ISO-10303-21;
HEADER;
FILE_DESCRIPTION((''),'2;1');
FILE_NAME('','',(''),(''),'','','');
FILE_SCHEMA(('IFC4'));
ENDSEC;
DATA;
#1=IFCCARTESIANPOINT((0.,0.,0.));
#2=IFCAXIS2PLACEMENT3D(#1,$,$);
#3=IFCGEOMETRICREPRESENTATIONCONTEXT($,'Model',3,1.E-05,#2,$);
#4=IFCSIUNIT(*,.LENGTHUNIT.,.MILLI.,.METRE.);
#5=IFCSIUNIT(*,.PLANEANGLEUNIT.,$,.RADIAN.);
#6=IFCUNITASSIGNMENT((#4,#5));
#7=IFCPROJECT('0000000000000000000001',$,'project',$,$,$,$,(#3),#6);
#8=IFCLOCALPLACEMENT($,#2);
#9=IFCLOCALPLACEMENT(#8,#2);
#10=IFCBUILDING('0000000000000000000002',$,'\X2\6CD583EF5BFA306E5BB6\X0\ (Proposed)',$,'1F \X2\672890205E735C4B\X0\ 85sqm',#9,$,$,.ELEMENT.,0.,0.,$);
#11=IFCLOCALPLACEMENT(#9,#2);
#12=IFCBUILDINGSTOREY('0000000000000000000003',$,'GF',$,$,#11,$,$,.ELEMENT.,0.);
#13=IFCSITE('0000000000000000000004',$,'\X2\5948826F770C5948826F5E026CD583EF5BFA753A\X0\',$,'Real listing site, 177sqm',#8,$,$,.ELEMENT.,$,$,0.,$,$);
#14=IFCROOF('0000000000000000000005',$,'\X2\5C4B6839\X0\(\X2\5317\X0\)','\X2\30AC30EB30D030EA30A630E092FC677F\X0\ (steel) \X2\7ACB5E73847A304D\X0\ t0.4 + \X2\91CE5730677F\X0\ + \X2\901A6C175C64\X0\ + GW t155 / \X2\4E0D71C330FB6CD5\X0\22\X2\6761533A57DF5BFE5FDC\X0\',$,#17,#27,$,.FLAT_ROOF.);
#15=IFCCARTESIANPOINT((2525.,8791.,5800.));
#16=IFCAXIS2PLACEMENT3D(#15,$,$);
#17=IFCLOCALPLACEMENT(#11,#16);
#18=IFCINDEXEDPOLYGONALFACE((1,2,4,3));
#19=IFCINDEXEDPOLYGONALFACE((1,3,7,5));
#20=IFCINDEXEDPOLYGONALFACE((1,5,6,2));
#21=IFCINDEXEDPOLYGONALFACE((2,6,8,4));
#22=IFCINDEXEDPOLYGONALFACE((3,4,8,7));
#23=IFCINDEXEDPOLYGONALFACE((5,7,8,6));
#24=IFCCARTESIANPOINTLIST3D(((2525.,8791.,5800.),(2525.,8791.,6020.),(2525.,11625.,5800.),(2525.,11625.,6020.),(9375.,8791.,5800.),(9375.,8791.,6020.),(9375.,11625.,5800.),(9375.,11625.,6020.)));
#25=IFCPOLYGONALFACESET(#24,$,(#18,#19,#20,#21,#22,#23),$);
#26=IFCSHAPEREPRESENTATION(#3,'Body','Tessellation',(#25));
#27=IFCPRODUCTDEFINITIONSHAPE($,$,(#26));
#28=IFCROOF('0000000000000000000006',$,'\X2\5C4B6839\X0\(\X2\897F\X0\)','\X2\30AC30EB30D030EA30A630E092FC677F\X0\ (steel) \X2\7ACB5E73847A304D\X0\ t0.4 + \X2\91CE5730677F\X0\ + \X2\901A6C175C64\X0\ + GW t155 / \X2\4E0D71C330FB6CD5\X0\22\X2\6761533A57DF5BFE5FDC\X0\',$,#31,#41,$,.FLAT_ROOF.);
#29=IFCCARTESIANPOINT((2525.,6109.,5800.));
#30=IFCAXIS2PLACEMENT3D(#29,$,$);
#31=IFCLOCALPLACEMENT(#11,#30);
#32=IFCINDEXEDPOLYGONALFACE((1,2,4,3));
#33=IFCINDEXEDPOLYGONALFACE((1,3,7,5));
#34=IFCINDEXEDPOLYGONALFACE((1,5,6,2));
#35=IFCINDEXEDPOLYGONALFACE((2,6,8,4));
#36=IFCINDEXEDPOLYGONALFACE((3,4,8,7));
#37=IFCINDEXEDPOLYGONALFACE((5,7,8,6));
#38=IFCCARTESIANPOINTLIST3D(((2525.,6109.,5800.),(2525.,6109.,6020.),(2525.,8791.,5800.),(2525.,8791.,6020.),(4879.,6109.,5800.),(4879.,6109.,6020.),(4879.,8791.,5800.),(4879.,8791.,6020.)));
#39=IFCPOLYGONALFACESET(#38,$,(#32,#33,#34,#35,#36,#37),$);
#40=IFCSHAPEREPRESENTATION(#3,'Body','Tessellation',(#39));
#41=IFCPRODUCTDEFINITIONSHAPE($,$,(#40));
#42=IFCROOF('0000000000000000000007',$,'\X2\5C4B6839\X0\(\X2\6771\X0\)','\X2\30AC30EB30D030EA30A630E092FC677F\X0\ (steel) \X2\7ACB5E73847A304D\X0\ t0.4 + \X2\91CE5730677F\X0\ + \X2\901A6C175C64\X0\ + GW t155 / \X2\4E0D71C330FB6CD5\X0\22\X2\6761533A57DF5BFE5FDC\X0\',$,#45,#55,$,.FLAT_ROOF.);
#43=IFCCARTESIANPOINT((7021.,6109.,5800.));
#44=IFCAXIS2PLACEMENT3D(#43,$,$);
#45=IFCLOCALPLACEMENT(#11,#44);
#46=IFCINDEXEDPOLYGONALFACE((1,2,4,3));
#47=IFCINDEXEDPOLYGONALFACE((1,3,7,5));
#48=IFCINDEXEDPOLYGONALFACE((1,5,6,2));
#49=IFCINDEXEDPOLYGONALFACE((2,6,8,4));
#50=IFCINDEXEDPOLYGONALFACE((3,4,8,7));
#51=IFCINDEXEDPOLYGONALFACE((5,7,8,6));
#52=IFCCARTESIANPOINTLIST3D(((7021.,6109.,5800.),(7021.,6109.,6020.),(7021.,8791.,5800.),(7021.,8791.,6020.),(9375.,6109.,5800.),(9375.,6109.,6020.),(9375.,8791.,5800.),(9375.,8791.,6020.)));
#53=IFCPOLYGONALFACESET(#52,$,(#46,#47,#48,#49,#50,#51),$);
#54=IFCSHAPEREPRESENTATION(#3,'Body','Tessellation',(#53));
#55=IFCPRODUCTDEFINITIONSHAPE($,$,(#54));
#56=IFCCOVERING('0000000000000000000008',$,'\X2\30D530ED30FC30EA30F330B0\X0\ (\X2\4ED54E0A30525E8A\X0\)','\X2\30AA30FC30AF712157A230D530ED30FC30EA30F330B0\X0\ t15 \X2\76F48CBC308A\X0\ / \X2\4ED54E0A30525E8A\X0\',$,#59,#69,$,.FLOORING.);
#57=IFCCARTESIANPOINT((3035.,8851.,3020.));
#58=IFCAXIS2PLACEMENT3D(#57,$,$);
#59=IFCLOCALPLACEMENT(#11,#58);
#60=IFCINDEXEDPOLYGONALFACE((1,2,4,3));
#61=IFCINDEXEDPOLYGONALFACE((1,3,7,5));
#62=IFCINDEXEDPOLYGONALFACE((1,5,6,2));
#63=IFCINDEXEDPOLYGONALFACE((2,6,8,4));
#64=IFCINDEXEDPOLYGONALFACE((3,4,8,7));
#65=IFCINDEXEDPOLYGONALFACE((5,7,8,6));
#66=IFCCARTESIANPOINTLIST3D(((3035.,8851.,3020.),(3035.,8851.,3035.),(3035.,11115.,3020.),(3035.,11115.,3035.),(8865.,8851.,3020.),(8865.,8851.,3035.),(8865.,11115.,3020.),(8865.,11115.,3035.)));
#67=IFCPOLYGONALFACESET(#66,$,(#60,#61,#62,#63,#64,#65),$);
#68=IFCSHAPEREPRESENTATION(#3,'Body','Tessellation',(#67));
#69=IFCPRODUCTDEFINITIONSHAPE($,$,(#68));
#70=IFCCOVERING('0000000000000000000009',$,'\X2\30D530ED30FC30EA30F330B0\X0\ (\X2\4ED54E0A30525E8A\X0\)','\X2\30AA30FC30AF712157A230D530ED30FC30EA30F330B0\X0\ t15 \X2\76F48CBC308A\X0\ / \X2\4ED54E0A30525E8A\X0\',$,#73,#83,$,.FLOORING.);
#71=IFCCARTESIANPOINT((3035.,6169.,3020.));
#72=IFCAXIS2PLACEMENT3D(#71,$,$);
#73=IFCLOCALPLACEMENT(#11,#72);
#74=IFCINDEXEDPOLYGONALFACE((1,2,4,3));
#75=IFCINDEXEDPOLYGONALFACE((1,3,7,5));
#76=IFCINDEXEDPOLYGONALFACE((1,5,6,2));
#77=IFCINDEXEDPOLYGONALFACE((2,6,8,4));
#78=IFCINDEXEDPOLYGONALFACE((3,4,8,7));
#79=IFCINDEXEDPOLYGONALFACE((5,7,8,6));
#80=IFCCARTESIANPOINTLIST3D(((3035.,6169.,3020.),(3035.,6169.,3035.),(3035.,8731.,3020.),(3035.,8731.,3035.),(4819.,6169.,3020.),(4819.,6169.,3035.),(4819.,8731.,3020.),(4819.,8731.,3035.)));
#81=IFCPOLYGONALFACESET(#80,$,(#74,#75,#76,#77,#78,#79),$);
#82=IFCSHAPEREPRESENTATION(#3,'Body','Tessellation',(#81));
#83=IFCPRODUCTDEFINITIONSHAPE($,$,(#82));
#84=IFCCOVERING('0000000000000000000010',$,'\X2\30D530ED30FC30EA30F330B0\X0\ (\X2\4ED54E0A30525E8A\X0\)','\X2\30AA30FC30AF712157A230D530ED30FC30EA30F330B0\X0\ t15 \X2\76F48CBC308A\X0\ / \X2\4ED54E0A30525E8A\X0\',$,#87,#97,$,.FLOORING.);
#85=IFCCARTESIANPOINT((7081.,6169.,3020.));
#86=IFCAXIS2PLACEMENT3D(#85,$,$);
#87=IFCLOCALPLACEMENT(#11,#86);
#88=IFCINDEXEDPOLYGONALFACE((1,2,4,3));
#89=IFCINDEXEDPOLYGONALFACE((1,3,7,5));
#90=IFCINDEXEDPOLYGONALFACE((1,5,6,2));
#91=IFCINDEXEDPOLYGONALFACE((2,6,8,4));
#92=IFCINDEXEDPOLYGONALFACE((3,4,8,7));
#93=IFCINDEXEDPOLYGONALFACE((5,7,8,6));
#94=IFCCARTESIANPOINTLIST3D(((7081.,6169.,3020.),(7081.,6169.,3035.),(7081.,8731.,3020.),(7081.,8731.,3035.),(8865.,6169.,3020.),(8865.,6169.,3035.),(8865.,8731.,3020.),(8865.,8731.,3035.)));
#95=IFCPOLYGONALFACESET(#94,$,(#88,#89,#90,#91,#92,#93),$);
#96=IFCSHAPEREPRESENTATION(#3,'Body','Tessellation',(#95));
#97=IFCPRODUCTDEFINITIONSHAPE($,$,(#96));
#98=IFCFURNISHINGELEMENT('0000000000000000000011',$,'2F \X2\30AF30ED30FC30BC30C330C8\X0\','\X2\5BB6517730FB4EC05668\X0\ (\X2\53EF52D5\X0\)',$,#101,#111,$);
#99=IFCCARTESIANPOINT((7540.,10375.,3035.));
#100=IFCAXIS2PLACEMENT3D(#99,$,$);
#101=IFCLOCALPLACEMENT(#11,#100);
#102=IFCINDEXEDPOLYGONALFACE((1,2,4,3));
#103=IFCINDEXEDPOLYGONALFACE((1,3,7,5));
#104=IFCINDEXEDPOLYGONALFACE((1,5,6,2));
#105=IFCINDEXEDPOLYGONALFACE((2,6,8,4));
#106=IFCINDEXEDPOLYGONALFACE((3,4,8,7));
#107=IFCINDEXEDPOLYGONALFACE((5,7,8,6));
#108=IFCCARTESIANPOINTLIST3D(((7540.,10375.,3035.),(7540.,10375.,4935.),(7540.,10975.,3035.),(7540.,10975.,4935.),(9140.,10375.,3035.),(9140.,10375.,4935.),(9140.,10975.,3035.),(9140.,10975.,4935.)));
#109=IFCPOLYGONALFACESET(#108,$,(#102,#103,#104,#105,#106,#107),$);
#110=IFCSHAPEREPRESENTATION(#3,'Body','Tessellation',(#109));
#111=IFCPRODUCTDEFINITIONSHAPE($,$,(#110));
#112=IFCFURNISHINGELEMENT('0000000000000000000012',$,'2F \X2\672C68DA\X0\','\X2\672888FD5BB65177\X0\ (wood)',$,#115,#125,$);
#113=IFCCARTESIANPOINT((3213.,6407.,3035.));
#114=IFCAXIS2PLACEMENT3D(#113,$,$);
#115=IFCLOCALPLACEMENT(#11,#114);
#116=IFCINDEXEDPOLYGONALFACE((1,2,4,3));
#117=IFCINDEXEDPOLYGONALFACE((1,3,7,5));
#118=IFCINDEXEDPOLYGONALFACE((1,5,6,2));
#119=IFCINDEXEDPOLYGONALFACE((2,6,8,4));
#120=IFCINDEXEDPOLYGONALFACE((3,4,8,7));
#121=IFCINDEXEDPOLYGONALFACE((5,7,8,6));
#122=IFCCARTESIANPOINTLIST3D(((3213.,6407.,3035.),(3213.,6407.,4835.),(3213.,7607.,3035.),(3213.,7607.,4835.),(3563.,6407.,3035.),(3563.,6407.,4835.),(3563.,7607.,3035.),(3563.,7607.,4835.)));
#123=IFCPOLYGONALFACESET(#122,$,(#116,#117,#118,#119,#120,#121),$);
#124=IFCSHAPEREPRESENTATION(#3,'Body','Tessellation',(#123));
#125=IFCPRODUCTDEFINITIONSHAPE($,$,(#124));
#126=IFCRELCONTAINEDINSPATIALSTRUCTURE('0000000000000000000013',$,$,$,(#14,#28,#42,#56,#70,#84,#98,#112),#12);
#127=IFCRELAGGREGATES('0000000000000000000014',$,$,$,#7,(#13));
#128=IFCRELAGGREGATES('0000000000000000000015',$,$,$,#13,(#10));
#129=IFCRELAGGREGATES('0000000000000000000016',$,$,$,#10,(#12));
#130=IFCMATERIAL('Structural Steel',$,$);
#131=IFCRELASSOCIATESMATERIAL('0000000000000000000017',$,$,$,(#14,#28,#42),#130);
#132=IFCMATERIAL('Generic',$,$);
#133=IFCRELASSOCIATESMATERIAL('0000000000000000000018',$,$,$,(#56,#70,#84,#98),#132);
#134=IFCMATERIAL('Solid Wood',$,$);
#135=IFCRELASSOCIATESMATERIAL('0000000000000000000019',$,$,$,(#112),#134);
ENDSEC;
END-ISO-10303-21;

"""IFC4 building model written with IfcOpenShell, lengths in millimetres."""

from ifc_helpers import new_model, si_unit, frame, frame_2d, origin, place, context, project, spatial, rectangle, extrude, material, element, save


model = new_model("IFC4")

# Units and contexts
model_context = context("Model", 3, precision=1e-05, world=origin())
ifc_project = project(units=[si_unit("LENGTHUNIT", "METRE", prefix="MILLI"), si_unit("PLANEANGLEUNIT", "RADIAN")], contexts=[model_context])

# Site, building, storey
site_placement = place(None, origin())
site = spatial("IfcSite", under=ifc_project, at=site_placement, Name="奈良県奈良市法華寺町", ObjectType="Real listing site, 177sqm", CompositionType="ELEMENT", RefElevation=0.0)
building_placement = place(site_placement, origin())
building = spatial("IfcBuilding", under=site, at=building_placement, Name="法華寺の家 (Proposed)", ObjectType="1F 木造平屋 85sqm", CompositionType="ELEMENT", ElevationOfRefHeight=0.0, ElevationOfTerrain=0.0)
storey_placement = place(building_placement, origin())
storey = spatial("IfcBuildingStorey", under=building, at=storey_placement, Name="GF", CompositionType="ELEMENT", Elevation=0.0)

# Shared definitions
ifc_material_1 = material(Name="Solid Wood")

# Shared definitions
ifc_material_2 = material(Name="Generic")

# Roofs
ifc_material_3 = material(Name="Structural Steel")
for number, where, name in (
    (1, (2525.0, 8791.0, 5800.0), "屋根(北)"),
):
    element("IfcRoof", number, at=place(storey_placement, frame(where)), inside=storey, material=ifc_material_3, Name=name, Description="ガルバリウム鋼板 (steel) 立平葺き t0.4 + 野地板 + 通気層 + GW t155 / 不燃・法22条区域対応", PredefinedType="FLAT_ROOF", context=model_context, shape_type="SweptSolid", body=[
        extrude(rectangle(XDim=6850.0, YDim=2834.0, at=frame_2d((3425.0, 1417.0))), frame((2525.0, 8791.0, 5800.0)), (0.0, 0.0, 1.0), 220.0),
    ])
roof_1_placement = place(storey_placement, frame((2525.0, 6109.0, 5800.0)))
element("IfcRoof", 2, at=roof_1_placement, inside=storey, material=ifc_material_3, Name="屋根(西)", Description="ガルバリウム鋼板 (steel) 立平葺き t0.4 + 野地板 + 通気層 + GW t155 / 不燃・法22条区域対応", PredefinedType="FLAT_ROOF", context=model_context, shape_type="SweptSolid", body=[
    extrude(rectangle(XDim=2354.0, YDim=2682.0, at=frame_2d((1177.0, 1341.0))), frame((2525.0, 6109.0, 5800.0)), (0.0, 0.0, 1.0), 220.0),
])
roof_2_placement = place(storey_placement, frame((7021.0, 6109.0, 5800.0)))
element("IfcRoof", 3, at=roof_2_placement, inside=storey, material=ifc_material_3, Name="屋根(東)", Description="ガルバリウム鋼板 (steel) 立平葺き t0.4 + 野地板 + 通気層 + GW t155 / 不燃・法22条区域対応", PredefinedType="FLAT_ROOF", context=model_context, shape_type="SweptSolid", body=[
    extrude(rectangle(XDim=2354.0, YDim=2682.0, at=frame_2d((1177.0, 1341.0))), frame((7021.0, 6109.0, 5800.0)), (0.0, 0.0, 1.0), 220.0),
])

# Coverings
covering_1_placement = place(storey_placement, frame((3035.0, 8851.0, 3020.0)))
element("IfcCovering", 4, at=covering_1_placement, inside=storey, material=ifc_material_2, Name="フローリング (仕上げ床)", Description="オーク無垢フローリング t15 直貼り / 仕上げ床", PredefinedType="FLOORING", context=model_context, shape_type="SweptSolid", body=[
    extrude(rectangle(XDim=5830.0, YDim=2264.0, at=frame_2d((2915.0, 1132.0))), frame((3035.0, 8851.0, 3020.0)), (0.0, 0.0, 1.0), 15.0),
])
covering_2_placement = place(storey_placement, frame((3035.0, 6169.0, 3020.0)))
element("IfcCovering", 5, at=covering_2_placement, inside=storey, material=ifc_material_2, Name="フローリング (仕上げ床)", Description="オーク無垢フローリング t15 直貼り / 仕上げ床", PredefinedType="FLOORING", context=model_context, shape_type="SweptSolid", body=[
    extrude(rectangle(XDim=1784.0, YDim=2562.0, at=frame_2d((892.0, 1281.0))), frame((3035.0, 6169.0, 3020.0)), (0.0, 0.0, 1.0), 15.0),
])
covering_3_placement = place(storey_placement, frame((7081.0, 6169.0, 3020.0)))
element("IfcCovering", 6, at=covering_3_placement, inside=storey, material=ifc_material_2, Name="フローリング (仕上げ床)", Description="オーク無垢フローリング t15 直貼り / 仕上げ床", PredefinedType="FLOORING", context=model_context, shape_type="SweptSolid", body=[
    extrude(rectangle(XDim=1784.0, YDim=2562.0, at=frame_2d((892.0, 1281.0))), frame((7081.0, 6169.0, 3020.0)), (0.0, 0.0, 1.0), 15.0),
])

# Furnishing elements
furnishing_1_placement = place(storey_placement, frame((7540.0, 10375.0, 3035.0)))
element("IfcFurnishingElement", 7, at=furnishing_1_placement, inside=storey, material=ifc_material_2, Name="2F クローゼット", Description="家具・什器 (可動)", context=model_context, shape_type="SweptSolid", body=[
    extrude(rectangle(XDim=1600.0, YDim=600.0, at=frame_2d((800.0, 300.0))), frame((7540.0, 10375.0, 3035.0)), (0.0, 0.0, 1.0), 1900.0),
])
furnishing_2_placement = place(storey_placement, frame((3213.0, 6407.0, 3035.0)))
element("IfcFurnishingElement", 8, at=furnishing_2_placement, inside=storey, material=ifc_material_1, Name="2F 本棚", Description="木製家具 (wood)", context=model_context, shape_type="SweptSolid", body=[
    extrude(rectangle(XDim=350.0, YDim=1200.0, at=frame_2d((175.0, 600.0))), frame((3213.0, 6407.0, 3035.0)), (0.0, 0.0, 1.0), 1800.0),
])

save(model, "model.ifc")
